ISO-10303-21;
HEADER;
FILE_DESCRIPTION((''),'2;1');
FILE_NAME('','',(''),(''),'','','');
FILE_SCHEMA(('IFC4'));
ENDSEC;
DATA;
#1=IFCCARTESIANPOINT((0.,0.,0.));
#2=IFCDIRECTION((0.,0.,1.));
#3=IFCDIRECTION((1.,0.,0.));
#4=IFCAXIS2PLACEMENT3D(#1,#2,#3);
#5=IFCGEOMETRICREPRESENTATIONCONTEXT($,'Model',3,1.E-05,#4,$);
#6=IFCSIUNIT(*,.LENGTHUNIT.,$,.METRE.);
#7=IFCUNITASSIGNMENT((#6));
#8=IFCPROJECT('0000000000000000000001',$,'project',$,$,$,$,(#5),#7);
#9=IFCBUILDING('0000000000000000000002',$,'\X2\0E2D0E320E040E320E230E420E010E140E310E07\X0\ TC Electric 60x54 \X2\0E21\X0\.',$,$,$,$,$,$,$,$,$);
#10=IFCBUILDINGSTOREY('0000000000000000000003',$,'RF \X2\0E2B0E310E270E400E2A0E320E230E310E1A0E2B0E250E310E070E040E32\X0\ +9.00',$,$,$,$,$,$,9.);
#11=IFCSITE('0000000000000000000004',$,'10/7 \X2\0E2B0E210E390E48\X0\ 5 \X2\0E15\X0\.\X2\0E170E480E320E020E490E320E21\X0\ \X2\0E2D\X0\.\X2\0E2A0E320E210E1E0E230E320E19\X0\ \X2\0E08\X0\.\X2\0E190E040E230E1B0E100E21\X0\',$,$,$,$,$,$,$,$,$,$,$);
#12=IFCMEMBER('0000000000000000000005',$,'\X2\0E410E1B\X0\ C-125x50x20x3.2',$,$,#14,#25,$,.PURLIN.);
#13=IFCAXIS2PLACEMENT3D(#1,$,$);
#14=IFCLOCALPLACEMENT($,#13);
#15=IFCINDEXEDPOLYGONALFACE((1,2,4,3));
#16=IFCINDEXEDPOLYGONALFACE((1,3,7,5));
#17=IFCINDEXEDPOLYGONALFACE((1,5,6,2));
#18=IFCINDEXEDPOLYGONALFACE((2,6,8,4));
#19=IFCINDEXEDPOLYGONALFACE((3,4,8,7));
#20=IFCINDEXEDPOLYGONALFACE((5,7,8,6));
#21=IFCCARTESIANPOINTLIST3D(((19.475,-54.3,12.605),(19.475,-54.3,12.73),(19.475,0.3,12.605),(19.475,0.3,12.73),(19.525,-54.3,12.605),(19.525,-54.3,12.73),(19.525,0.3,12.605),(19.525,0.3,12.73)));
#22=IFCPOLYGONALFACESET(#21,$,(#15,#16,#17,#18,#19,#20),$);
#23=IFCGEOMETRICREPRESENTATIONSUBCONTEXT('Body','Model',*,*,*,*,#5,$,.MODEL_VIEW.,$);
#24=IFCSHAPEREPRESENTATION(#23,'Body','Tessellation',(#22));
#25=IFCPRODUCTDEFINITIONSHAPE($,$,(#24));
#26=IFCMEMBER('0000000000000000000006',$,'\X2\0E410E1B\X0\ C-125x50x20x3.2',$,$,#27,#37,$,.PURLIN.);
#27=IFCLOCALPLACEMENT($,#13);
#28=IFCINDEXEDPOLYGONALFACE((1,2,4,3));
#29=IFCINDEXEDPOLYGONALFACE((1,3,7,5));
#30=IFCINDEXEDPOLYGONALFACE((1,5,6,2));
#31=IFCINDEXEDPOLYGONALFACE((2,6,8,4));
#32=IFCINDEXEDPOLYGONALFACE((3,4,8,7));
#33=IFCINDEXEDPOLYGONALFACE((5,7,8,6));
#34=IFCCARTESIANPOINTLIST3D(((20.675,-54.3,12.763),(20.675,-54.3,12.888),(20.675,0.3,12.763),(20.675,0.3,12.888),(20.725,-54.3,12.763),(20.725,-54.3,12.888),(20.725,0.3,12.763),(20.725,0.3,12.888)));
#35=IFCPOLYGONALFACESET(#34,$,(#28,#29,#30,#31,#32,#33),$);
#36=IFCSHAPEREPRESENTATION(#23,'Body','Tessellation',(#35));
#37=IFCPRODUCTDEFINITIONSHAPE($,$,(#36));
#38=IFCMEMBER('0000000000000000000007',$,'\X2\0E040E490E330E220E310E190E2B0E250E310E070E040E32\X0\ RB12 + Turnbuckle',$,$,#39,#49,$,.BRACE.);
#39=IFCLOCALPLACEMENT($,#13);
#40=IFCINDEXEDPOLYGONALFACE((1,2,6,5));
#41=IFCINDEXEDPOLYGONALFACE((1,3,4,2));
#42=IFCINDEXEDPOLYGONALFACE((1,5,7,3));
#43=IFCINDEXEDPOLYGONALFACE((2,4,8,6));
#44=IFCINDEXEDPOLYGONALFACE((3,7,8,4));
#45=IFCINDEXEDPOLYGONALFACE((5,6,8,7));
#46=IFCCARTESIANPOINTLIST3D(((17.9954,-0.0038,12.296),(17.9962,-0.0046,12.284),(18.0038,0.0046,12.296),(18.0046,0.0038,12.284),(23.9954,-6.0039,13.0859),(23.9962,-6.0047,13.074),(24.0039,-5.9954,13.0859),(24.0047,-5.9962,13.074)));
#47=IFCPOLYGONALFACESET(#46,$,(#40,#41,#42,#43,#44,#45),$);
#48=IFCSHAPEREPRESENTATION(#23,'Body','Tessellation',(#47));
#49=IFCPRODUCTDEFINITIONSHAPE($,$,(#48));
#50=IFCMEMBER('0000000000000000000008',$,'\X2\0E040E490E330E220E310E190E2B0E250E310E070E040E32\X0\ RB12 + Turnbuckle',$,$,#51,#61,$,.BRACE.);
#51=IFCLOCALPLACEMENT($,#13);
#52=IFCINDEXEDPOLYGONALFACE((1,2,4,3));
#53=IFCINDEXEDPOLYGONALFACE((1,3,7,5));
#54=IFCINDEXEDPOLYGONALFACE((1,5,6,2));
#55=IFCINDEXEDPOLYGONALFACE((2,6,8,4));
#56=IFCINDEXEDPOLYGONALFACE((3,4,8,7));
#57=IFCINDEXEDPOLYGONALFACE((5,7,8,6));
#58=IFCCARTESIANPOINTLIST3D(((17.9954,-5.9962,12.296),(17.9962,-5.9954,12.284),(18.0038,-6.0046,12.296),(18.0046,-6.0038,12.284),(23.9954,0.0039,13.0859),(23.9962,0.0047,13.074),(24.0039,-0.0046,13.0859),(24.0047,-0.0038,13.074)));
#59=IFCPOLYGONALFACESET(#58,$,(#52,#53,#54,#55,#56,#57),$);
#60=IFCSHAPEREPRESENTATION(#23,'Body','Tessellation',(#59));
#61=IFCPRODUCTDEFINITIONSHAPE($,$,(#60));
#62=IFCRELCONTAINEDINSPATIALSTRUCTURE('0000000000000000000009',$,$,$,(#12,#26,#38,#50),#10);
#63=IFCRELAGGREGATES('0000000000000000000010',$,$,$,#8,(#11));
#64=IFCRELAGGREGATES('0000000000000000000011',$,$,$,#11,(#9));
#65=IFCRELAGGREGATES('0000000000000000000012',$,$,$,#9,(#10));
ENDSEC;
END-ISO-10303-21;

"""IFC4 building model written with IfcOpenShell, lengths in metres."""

from ifc_helpers import new_model, si_unit, frame, origin, origin_with_axes, origin_2d, place, context, subcontext, project, spatial, rectangle, extrude, element, save


model = new_model("IFC4")

# Units and contexts
model_context = context("Model", 3, precision=1e-05, world=origin_with_axes())
body_context = subcontext(model_context, "Body", "Model", "MODEL_VIEW")
ifc_project = project(units=[si_unit("LENGTHUNIT", "METRE")], contexts=[model_context])

# Site, building, storey
site = spatial("IfcSite", under=ifc_project, Name="10/7 หมู่ 5 ต.ท่าข้าม อ.สามพราน จ.นครปฐม")
building = spatial("IfcBuilding", under=site, Name="อาคารโกดัง TC Electric 60x54 ม.")
storey = spatial("IfcBuildingStorey", under=building, Name="RF หัวเสารับหลังคา +9.00", Elevation=9.0)

# Members
for number, where, z_axis, x_axis, name in (
    (1, (19.5, 0.3, 12.6675), (0.0, -1.0, 0.0), (-1.0, 0.0, 0.0), "แป C-125x50x20x3.2"),
    (2, (20.7, 0.3, 12.8255), (0.0, -1.0, 0.0), (-1.0, 0.0, 0.0), "แป C-125x50x20x3.2"),
):
    element("IfcMember", number, at=place(None, frame(where, z_axis=z_axis, x_axis=x_axis)), inside=storey, Name=name, PredefinedType="PURLIN", context=body_context, shape_type="SweptSolid", body=[
        extrude(rectangle(XDim=0.05, YDim=0.125, at=origin_2d()), origin(), (0.0, 0.0, 1.0), 54.6),
    ])
for number, where, z_axis, x_axis, name in (
    (3, (18.0, 0.0, 12.29), (0.7041, -0.7041, 0.0927), (-0.7071, -0.7071, 0.0), "ค้ำยันหลังคา RB12 + Turnbuckle"),
    (4, (18.0, -6.0, 12.29), (0.7041, 0.7041, 0.0927), (0.7071, -0.7071, 0.0), "ค้ำยันหลังคา RB12 + Turnbuckle"),
):
    element("IfcMember", number, at=place(None, frame(where, z_axis=z_axis, x_axis=x_axis)), inside=storey, Name=name, PredefinedType="BRACE", context=body_context, shape_type="SweptSolid", body=[
        extrude(rectangle(XDim=0.012, YDim=0.012, at=origin_2d()), origin(), (0.0, 0.0, 1.0), 8.522),
    ])

save(model, "model.ifc")
